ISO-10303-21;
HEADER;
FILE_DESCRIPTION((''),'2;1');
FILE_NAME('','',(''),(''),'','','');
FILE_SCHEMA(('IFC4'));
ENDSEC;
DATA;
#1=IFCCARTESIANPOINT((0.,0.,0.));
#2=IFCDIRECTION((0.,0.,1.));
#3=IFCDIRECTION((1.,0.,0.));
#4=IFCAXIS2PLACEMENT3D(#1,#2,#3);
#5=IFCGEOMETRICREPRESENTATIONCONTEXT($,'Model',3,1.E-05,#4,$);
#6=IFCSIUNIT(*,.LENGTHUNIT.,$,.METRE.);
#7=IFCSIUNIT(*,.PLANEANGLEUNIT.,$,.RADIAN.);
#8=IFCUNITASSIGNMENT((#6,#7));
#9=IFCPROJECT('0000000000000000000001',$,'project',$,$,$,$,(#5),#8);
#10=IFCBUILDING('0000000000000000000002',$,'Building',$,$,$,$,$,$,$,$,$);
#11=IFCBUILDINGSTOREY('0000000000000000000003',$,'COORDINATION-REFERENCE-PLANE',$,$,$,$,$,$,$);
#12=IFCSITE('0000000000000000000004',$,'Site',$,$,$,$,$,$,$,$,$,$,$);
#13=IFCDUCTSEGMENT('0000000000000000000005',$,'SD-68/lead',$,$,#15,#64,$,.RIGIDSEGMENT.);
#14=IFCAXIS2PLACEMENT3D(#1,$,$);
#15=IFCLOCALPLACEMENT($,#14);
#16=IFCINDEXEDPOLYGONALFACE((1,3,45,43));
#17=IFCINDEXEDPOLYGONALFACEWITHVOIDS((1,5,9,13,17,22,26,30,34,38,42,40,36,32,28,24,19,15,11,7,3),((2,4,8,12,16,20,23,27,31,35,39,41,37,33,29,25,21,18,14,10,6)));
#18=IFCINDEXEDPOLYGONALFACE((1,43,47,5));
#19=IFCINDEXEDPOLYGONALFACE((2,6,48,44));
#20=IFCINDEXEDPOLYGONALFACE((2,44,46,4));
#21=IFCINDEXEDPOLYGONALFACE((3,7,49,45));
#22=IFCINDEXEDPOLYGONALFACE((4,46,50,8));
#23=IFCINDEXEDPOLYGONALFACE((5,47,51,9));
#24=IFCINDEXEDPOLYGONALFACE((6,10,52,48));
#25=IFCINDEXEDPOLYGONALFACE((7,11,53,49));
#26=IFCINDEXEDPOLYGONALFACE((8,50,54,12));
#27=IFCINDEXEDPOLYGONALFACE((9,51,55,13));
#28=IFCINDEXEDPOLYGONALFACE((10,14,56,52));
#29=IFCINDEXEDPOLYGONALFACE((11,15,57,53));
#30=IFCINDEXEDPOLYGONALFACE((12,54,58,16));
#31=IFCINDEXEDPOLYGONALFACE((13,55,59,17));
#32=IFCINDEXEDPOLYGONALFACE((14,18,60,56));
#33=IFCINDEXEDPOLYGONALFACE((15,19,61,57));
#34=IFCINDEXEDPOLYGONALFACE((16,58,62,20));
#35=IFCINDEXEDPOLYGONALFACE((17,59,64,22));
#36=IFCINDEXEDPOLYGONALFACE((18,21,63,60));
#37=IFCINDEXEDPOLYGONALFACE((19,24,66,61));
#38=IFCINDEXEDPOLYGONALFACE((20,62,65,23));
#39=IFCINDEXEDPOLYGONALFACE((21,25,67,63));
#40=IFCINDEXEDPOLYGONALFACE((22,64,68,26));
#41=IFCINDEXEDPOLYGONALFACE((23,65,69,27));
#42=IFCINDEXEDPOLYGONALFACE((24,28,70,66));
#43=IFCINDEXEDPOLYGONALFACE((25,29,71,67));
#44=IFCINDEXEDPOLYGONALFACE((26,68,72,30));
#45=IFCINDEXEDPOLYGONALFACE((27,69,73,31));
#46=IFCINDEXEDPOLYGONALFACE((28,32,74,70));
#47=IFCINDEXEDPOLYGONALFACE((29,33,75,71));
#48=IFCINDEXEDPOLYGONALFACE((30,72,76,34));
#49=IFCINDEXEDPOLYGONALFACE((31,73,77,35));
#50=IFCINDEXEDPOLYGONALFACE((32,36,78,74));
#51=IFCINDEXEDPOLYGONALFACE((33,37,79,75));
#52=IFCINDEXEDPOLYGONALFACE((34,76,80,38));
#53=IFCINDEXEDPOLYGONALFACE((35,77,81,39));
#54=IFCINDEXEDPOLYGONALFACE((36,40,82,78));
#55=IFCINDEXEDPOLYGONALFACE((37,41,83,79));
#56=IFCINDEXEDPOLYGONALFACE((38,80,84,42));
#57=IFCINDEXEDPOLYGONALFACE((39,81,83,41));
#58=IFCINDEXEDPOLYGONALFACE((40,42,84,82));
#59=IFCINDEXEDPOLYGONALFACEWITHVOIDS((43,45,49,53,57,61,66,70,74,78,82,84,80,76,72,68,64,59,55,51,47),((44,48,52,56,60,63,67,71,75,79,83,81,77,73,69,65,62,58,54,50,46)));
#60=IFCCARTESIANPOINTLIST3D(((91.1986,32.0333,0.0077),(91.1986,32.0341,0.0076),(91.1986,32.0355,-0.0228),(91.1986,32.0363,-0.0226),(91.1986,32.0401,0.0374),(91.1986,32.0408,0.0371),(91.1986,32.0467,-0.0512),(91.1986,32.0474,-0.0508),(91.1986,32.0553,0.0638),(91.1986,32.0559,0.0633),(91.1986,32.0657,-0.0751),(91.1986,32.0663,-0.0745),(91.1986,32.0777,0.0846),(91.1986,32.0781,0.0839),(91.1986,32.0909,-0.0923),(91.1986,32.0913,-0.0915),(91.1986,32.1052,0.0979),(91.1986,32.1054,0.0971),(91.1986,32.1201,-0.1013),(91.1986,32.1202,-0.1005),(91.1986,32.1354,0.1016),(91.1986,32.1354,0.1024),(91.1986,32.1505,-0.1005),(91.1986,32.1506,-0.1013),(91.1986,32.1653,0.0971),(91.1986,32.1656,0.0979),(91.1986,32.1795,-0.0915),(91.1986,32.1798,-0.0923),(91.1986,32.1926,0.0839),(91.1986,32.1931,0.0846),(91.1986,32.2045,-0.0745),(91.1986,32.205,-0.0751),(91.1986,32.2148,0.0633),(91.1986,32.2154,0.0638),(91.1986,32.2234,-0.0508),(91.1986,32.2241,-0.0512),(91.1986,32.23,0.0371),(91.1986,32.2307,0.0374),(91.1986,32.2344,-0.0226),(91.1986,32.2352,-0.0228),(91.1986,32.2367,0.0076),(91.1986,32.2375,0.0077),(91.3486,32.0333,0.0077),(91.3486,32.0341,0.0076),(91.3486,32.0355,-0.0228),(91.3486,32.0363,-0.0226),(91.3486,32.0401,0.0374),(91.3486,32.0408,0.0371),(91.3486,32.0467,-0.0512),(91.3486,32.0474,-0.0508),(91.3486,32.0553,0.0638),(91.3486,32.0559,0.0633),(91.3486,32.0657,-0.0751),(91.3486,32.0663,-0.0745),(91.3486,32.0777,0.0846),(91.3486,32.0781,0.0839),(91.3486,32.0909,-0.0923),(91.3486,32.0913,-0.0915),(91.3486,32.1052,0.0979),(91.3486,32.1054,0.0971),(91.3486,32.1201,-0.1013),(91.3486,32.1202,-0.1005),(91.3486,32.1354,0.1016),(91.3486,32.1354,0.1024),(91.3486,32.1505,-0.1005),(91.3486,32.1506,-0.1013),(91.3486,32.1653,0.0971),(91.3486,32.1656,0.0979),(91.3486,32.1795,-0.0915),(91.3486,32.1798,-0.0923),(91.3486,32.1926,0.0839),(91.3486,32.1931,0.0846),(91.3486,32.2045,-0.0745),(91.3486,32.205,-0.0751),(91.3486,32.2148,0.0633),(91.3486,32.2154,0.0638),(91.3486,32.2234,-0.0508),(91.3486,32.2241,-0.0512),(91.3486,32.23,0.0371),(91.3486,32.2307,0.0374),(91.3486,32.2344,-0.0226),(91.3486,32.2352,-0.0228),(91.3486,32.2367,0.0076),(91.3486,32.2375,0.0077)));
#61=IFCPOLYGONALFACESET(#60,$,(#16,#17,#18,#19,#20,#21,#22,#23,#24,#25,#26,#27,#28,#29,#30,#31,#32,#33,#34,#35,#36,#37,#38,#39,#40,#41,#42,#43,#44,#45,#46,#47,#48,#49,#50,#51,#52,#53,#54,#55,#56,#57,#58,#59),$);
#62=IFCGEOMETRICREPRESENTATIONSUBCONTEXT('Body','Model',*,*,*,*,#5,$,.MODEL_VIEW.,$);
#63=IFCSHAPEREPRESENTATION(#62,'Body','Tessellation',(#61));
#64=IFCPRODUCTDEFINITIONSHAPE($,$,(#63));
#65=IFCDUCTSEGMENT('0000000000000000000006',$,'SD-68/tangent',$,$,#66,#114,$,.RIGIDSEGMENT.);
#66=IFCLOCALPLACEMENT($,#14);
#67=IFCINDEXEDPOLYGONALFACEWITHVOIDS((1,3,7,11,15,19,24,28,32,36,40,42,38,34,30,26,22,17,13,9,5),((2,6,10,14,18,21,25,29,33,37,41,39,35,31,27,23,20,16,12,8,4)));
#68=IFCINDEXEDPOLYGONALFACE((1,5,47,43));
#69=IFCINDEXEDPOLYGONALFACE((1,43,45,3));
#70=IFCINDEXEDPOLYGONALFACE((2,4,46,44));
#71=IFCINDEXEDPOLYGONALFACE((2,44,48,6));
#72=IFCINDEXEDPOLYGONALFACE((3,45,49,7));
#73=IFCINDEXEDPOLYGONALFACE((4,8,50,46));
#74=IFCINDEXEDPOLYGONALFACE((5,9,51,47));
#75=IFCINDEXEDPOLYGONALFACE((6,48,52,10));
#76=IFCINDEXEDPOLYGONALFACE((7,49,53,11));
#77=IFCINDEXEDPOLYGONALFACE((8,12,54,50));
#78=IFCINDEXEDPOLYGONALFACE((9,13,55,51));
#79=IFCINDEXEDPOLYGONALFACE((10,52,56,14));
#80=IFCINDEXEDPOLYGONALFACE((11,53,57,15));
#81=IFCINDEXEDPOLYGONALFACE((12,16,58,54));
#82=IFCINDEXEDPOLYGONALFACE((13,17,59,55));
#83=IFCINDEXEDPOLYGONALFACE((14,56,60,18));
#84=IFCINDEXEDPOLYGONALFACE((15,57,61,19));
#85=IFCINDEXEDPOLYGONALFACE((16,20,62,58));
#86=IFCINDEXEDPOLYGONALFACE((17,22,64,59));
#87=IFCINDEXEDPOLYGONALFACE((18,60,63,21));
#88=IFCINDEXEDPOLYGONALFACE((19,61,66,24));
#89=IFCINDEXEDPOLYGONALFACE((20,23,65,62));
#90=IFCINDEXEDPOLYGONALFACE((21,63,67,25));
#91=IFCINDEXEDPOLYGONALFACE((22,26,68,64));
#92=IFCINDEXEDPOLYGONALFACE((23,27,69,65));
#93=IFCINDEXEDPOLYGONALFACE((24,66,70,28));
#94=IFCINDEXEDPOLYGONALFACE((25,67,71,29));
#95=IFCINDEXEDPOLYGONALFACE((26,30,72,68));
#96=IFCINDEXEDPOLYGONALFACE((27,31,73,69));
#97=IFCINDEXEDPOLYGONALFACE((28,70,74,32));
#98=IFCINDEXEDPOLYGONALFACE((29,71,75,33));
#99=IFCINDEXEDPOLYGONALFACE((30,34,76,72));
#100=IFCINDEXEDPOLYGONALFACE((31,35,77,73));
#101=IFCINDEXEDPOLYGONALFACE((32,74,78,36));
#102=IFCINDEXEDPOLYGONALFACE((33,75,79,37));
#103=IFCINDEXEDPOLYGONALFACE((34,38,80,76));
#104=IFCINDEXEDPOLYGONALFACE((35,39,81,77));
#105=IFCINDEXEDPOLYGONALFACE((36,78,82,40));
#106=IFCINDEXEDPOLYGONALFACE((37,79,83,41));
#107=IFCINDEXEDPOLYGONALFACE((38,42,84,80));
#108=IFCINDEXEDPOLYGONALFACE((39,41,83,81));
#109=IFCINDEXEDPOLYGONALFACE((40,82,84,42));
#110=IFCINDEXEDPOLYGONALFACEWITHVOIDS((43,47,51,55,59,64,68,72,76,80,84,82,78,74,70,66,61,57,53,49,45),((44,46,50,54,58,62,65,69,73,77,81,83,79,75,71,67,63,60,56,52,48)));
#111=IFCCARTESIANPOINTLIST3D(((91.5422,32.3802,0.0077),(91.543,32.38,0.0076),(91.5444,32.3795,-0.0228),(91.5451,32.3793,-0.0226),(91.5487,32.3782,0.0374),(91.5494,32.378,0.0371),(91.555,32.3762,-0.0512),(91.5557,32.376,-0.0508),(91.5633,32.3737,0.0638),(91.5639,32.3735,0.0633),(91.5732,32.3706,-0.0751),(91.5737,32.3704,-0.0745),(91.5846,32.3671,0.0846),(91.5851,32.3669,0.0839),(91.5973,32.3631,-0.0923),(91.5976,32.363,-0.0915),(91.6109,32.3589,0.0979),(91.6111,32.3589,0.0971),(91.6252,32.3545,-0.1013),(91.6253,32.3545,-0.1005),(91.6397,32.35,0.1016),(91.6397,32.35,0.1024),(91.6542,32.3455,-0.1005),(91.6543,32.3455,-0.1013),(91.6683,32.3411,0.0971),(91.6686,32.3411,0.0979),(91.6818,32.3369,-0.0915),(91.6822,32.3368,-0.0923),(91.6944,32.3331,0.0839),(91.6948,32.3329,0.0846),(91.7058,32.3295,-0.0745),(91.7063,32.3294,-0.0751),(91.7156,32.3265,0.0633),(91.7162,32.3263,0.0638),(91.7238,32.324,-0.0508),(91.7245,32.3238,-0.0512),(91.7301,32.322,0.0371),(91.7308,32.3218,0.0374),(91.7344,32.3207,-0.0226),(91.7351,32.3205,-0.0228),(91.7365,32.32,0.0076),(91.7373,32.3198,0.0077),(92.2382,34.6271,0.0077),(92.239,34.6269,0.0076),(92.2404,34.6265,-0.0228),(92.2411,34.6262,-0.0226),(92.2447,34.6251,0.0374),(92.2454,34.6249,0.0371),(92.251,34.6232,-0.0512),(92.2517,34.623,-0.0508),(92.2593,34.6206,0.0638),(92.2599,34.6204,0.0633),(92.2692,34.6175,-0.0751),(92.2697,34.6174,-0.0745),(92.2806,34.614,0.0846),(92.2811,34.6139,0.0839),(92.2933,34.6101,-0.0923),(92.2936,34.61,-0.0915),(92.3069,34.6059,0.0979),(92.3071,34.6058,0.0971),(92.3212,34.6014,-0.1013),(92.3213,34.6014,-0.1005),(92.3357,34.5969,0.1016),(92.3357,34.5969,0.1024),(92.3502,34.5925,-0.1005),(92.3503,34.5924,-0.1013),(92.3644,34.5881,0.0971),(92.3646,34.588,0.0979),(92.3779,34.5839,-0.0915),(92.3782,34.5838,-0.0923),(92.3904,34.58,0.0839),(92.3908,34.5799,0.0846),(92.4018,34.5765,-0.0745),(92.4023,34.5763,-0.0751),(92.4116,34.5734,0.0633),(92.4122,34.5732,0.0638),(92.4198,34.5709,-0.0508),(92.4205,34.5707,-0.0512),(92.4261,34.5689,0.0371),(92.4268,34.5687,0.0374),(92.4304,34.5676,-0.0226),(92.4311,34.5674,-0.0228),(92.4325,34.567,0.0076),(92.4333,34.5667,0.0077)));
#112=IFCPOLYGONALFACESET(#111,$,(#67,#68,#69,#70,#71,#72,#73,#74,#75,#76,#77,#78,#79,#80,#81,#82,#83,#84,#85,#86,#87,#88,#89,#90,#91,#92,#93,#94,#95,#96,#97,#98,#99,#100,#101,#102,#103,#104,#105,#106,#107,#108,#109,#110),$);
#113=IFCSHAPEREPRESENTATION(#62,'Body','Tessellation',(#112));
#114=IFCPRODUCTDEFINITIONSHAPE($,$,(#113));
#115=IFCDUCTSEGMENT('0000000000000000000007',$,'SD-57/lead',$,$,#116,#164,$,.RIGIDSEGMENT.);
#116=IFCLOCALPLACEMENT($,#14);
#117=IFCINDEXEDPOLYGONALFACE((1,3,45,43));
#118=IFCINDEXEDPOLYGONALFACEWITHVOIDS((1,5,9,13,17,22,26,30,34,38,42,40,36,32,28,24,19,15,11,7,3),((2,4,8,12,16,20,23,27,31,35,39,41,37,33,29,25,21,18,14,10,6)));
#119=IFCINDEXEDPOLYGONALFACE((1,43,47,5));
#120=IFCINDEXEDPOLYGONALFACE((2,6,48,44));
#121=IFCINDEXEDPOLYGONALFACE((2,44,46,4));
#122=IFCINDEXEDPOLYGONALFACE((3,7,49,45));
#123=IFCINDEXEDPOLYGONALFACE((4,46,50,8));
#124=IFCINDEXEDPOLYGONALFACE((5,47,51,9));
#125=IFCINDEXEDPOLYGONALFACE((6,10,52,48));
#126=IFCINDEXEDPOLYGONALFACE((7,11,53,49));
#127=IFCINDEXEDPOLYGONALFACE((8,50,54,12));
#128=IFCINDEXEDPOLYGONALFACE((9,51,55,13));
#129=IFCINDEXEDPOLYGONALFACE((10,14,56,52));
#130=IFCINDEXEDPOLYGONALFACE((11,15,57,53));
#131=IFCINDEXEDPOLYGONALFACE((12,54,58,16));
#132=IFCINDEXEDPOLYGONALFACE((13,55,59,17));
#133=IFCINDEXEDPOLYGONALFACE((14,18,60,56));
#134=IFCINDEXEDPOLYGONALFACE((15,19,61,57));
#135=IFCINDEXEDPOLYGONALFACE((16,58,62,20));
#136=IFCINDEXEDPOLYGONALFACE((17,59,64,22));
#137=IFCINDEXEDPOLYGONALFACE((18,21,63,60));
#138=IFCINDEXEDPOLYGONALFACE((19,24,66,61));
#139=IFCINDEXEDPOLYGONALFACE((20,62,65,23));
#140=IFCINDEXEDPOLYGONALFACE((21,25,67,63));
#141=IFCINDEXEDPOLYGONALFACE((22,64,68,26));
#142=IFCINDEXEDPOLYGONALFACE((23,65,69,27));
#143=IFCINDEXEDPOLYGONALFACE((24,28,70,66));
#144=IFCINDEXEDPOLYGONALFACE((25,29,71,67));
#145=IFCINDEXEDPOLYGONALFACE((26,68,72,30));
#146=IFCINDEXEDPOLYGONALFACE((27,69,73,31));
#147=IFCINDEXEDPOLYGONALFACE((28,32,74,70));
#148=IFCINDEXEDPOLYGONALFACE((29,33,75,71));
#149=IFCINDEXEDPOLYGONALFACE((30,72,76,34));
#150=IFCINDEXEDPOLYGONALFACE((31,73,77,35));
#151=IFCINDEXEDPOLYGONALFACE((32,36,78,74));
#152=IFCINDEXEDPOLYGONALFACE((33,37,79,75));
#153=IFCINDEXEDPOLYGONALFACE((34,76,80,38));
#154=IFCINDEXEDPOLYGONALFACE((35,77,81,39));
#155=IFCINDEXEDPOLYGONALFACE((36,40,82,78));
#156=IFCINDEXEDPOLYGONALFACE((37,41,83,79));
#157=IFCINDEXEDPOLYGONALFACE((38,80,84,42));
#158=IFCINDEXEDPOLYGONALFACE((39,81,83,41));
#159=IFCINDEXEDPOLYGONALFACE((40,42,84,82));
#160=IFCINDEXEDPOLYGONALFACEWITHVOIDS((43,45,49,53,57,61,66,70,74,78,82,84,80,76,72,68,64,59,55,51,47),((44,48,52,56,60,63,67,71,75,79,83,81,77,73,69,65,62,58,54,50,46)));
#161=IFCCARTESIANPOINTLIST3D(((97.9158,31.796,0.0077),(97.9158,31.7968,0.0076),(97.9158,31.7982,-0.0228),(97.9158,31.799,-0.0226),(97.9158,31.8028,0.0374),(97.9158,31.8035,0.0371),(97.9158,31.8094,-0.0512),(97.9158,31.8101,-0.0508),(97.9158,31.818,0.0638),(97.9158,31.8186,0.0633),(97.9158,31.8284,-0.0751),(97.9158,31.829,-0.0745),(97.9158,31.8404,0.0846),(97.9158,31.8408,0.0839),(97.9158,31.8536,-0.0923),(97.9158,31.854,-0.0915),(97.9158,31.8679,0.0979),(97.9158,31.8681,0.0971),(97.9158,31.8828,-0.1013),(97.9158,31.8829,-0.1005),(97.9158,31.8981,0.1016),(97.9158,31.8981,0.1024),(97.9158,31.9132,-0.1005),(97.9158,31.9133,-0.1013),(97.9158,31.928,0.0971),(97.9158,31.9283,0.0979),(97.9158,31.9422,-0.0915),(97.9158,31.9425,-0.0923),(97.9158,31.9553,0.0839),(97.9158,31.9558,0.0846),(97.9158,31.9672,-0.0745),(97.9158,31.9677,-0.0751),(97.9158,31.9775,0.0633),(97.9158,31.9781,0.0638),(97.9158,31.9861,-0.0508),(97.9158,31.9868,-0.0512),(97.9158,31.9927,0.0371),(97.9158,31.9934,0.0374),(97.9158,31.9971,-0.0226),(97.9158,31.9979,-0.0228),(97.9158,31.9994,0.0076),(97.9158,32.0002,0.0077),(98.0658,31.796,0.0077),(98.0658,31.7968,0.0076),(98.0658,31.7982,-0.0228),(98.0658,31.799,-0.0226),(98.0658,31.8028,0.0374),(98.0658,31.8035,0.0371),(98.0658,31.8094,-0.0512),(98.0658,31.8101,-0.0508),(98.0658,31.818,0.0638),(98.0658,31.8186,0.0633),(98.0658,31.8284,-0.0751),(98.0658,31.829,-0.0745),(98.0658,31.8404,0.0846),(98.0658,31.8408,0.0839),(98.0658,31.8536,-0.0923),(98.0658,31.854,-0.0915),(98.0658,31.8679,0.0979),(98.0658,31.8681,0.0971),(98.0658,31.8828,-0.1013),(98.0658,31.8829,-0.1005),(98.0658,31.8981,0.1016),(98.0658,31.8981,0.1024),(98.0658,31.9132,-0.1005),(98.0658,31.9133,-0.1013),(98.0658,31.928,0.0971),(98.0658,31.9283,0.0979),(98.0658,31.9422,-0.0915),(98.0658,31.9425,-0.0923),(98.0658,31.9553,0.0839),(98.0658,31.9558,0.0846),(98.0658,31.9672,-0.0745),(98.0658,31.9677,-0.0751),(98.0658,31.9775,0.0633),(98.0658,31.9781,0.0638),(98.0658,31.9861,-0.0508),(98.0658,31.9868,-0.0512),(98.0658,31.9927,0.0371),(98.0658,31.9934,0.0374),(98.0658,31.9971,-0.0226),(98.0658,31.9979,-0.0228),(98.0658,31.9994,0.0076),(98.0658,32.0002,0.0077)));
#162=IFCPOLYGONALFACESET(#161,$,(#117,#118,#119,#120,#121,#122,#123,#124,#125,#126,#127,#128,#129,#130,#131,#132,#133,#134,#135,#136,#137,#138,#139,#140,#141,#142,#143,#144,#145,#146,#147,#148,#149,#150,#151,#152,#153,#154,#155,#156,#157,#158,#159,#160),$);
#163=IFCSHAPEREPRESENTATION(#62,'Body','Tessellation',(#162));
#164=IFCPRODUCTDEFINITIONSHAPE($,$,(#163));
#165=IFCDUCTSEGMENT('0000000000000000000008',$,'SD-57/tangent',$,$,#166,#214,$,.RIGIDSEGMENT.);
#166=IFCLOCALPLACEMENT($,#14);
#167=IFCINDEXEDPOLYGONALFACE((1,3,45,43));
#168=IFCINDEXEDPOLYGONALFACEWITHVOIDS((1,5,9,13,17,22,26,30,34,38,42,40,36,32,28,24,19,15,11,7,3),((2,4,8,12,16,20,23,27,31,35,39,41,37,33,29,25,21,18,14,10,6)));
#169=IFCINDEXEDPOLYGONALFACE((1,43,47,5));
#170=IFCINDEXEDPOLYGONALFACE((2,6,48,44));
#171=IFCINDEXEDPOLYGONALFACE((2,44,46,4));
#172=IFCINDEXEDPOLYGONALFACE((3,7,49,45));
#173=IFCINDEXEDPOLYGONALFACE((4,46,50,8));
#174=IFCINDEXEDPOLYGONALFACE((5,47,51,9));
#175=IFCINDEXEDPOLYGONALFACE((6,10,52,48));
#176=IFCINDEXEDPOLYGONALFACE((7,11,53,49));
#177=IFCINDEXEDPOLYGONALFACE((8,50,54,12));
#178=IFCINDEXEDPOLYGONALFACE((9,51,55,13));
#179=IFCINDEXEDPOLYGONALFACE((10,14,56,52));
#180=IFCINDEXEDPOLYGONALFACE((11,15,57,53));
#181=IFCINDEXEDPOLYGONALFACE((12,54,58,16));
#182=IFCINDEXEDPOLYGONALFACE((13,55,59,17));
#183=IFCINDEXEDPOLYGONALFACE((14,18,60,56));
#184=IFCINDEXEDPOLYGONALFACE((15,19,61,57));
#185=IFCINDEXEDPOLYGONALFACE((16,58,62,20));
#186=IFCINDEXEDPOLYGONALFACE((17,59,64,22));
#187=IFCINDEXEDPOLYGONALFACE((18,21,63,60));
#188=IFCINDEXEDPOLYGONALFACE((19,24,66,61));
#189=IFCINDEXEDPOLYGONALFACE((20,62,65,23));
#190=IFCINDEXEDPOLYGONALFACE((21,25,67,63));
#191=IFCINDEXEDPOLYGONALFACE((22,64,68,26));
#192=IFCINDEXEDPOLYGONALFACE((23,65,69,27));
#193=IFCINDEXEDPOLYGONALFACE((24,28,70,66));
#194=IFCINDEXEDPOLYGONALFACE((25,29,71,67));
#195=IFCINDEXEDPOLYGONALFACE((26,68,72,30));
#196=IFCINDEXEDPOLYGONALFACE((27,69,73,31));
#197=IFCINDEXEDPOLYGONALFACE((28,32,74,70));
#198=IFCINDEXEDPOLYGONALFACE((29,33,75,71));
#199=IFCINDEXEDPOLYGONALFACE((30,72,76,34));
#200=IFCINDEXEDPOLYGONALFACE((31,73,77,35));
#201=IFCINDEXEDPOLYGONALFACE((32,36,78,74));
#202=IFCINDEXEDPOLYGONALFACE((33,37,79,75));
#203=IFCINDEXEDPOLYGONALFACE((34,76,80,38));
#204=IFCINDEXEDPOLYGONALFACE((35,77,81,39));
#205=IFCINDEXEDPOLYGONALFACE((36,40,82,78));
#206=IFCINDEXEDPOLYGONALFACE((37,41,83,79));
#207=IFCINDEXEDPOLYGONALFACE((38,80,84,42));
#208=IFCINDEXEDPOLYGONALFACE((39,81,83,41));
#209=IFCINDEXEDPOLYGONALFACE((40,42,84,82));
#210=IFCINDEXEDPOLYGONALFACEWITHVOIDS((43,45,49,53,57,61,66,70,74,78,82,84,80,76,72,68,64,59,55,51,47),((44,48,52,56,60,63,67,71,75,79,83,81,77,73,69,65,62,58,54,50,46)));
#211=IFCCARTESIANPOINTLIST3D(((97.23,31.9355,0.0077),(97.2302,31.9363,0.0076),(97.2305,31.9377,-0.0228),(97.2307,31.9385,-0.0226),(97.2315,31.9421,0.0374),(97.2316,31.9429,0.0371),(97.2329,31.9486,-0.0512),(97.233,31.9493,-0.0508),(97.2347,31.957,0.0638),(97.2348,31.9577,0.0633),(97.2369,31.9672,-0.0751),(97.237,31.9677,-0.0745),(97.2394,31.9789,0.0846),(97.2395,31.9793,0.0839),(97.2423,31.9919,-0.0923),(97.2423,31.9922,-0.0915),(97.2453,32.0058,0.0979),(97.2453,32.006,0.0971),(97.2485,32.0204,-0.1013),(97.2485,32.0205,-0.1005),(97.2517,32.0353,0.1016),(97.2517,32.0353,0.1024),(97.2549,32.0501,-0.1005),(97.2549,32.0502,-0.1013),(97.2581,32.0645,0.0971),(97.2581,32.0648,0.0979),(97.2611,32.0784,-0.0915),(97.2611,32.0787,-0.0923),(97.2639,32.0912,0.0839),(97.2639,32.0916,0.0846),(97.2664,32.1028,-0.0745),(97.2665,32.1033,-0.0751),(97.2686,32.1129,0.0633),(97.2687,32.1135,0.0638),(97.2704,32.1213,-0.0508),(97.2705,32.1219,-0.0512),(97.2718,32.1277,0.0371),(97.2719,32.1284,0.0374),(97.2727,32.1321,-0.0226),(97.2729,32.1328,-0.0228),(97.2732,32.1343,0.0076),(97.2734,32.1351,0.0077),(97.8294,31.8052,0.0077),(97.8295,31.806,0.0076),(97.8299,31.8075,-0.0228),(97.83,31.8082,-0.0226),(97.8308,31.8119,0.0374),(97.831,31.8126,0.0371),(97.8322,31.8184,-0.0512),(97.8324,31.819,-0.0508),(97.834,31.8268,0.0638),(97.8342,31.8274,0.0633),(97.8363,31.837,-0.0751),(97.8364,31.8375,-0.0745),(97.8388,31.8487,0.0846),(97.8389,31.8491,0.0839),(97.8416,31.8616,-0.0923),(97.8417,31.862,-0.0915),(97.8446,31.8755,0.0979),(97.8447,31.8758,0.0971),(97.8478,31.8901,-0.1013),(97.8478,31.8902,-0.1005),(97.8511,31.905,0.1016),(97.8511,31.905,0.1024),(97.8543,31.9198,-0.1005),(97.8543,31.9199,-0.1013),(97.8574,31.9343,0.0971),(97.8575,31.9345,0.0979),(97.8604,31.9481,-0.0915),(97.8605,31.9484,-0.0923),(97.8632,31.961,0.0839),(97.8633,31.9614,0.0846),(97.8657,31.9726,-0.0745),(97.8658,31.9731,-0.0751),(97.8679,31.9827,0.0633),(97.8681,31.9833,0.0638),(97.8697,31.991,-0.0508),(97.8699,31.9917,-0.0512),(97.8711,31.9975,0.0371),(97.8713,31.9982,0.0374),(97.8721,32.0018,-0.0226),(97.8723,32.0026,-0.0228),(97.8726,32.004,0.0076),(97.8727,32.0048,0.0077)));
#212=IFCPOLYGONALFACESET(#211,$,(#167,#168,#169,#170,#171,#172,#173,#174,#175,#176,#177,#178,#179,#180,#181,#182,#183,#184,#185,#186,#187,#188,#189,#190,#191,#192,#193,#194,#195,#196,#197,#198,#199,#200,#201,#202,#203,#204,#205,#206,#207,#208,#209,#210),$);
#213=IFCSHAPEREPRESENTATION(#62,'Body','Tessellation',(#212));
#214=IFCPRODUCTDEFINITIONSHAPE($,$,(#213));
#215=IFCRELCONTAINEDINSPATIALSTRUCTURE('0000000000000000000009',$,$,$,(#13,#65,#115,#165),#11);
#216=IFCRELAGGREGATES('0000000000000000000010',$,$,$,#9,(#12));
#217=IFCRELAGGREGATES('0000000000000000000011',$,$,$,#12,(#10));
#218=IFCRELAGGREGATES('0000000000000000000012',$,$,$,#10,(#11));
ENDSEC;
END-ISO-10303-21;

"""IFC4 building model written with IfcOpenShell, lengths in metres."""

from ifc_helpers import new_model, si_unit, frame, origin_with_axes, place, context, subcontext, project, spatial, hollow_circle, extrude, element, save


model = new_model("IFC4")

# Units and contexts
model_context = context("Model", 3, precision=1e-05, world=origin_with_axes())
body_context_1 = subcontext(model_context, "Body", "Model", "MODEL_VIEW")
ifc_project = project(units=[si_unit("LENGTHUNIT", "METRE"), si_unit("PLANEANGLEUNIT", "RADIAN")], contexts=[model_context])

# Site, building, storey
site = spatial("IfcSite", under=ifc_project, Name="Site")
building = spatial("IfcBuilding", under=site, Name="Building")
storey = spatial("IfcBuildingStorey", under=building, Name="COORDINATION-REFERENCE-PLANE")

# Duct segments
duct_segment_1_placement = place(None, frame((91.1986, 32.1354, 0.0), z_axis=(1.0, 0.0, 0.0), x_axis=(0.0, 0.0, 1.0)))
element("IfcDuctSegment", 1, at=duct_segment_1_placement, inside=storey, Name="SD-68/lead", PredefinedType="RIGIDSEGMENT", context=body_context_1, shape_type="SweptSolid", body=[
    extrude(hollow_circle(Radius=0.1024, WallThickness=0.0008), origin_with_axes(), (0.0, 0.0, 1.0), 0.15),
])
duct_segment_2_placement = place(None, frame((91.6397, 32.35, 0.0), z_axis=(0.295887, 0.955223, 0.0), x_axis=(0.0, 0.0, 1.0)))
element("IfcDuctSegment", 2, at=duct_segment_2_placement, inside=storey, Name="SD-68/tangent", PredefinedType="RIGIDSEGMENT", context=body_context_1, shape_type="SweptSolid", body=[
    extrude(hollow_circle(Radius=0.1024, WallThickness=0.0008), origin_with_axes(), (0.0, 0.0, 1.0), 2.3523),
])
duct_segment_3_placement = place(None, frame((98.0658, 31.8981, 0.0), z_axis=(-1.0, 0.0, 0.0), x_axis=(0.0, 0.0, 1.0)))
element("IfcDuctSegment", 3, at=duct_segment_3_placement, inside=storey, Name="SD-57/lead", PredefinedType="RIGIDSEGMENT", context=body_context_1, shape_type="SweptSolid", body=[
    extrude(hollow_circle(Radius=0.1024, WallThickness=0.0008), origin_with_axes(), (0.0, 0.0, 1.0), 0.15),
])

# Duct segment
duct_segment_4_placement = place(None, frame((97.8511, 31.905, 0.0), z_axis=(-0.977193, 0.212353, 0.0), x_axis=(0.0, 0.0, 1.0)))
element("IfcDuctSegment", 4, at=duct_segment_4_placement, inside=storey, Name="SD-57/tangent", PredefinedType="RIGIDSEGMENT", context=body_context_1, shape_type="SweptSolid", body=[
    extrude(hollow_circle(Radius=0.1024, WallThickness=0.0008), origin_with_axes(), (0.0, 0.0, 1.0), 0.6133),
])

save(model, "model.ifc")
